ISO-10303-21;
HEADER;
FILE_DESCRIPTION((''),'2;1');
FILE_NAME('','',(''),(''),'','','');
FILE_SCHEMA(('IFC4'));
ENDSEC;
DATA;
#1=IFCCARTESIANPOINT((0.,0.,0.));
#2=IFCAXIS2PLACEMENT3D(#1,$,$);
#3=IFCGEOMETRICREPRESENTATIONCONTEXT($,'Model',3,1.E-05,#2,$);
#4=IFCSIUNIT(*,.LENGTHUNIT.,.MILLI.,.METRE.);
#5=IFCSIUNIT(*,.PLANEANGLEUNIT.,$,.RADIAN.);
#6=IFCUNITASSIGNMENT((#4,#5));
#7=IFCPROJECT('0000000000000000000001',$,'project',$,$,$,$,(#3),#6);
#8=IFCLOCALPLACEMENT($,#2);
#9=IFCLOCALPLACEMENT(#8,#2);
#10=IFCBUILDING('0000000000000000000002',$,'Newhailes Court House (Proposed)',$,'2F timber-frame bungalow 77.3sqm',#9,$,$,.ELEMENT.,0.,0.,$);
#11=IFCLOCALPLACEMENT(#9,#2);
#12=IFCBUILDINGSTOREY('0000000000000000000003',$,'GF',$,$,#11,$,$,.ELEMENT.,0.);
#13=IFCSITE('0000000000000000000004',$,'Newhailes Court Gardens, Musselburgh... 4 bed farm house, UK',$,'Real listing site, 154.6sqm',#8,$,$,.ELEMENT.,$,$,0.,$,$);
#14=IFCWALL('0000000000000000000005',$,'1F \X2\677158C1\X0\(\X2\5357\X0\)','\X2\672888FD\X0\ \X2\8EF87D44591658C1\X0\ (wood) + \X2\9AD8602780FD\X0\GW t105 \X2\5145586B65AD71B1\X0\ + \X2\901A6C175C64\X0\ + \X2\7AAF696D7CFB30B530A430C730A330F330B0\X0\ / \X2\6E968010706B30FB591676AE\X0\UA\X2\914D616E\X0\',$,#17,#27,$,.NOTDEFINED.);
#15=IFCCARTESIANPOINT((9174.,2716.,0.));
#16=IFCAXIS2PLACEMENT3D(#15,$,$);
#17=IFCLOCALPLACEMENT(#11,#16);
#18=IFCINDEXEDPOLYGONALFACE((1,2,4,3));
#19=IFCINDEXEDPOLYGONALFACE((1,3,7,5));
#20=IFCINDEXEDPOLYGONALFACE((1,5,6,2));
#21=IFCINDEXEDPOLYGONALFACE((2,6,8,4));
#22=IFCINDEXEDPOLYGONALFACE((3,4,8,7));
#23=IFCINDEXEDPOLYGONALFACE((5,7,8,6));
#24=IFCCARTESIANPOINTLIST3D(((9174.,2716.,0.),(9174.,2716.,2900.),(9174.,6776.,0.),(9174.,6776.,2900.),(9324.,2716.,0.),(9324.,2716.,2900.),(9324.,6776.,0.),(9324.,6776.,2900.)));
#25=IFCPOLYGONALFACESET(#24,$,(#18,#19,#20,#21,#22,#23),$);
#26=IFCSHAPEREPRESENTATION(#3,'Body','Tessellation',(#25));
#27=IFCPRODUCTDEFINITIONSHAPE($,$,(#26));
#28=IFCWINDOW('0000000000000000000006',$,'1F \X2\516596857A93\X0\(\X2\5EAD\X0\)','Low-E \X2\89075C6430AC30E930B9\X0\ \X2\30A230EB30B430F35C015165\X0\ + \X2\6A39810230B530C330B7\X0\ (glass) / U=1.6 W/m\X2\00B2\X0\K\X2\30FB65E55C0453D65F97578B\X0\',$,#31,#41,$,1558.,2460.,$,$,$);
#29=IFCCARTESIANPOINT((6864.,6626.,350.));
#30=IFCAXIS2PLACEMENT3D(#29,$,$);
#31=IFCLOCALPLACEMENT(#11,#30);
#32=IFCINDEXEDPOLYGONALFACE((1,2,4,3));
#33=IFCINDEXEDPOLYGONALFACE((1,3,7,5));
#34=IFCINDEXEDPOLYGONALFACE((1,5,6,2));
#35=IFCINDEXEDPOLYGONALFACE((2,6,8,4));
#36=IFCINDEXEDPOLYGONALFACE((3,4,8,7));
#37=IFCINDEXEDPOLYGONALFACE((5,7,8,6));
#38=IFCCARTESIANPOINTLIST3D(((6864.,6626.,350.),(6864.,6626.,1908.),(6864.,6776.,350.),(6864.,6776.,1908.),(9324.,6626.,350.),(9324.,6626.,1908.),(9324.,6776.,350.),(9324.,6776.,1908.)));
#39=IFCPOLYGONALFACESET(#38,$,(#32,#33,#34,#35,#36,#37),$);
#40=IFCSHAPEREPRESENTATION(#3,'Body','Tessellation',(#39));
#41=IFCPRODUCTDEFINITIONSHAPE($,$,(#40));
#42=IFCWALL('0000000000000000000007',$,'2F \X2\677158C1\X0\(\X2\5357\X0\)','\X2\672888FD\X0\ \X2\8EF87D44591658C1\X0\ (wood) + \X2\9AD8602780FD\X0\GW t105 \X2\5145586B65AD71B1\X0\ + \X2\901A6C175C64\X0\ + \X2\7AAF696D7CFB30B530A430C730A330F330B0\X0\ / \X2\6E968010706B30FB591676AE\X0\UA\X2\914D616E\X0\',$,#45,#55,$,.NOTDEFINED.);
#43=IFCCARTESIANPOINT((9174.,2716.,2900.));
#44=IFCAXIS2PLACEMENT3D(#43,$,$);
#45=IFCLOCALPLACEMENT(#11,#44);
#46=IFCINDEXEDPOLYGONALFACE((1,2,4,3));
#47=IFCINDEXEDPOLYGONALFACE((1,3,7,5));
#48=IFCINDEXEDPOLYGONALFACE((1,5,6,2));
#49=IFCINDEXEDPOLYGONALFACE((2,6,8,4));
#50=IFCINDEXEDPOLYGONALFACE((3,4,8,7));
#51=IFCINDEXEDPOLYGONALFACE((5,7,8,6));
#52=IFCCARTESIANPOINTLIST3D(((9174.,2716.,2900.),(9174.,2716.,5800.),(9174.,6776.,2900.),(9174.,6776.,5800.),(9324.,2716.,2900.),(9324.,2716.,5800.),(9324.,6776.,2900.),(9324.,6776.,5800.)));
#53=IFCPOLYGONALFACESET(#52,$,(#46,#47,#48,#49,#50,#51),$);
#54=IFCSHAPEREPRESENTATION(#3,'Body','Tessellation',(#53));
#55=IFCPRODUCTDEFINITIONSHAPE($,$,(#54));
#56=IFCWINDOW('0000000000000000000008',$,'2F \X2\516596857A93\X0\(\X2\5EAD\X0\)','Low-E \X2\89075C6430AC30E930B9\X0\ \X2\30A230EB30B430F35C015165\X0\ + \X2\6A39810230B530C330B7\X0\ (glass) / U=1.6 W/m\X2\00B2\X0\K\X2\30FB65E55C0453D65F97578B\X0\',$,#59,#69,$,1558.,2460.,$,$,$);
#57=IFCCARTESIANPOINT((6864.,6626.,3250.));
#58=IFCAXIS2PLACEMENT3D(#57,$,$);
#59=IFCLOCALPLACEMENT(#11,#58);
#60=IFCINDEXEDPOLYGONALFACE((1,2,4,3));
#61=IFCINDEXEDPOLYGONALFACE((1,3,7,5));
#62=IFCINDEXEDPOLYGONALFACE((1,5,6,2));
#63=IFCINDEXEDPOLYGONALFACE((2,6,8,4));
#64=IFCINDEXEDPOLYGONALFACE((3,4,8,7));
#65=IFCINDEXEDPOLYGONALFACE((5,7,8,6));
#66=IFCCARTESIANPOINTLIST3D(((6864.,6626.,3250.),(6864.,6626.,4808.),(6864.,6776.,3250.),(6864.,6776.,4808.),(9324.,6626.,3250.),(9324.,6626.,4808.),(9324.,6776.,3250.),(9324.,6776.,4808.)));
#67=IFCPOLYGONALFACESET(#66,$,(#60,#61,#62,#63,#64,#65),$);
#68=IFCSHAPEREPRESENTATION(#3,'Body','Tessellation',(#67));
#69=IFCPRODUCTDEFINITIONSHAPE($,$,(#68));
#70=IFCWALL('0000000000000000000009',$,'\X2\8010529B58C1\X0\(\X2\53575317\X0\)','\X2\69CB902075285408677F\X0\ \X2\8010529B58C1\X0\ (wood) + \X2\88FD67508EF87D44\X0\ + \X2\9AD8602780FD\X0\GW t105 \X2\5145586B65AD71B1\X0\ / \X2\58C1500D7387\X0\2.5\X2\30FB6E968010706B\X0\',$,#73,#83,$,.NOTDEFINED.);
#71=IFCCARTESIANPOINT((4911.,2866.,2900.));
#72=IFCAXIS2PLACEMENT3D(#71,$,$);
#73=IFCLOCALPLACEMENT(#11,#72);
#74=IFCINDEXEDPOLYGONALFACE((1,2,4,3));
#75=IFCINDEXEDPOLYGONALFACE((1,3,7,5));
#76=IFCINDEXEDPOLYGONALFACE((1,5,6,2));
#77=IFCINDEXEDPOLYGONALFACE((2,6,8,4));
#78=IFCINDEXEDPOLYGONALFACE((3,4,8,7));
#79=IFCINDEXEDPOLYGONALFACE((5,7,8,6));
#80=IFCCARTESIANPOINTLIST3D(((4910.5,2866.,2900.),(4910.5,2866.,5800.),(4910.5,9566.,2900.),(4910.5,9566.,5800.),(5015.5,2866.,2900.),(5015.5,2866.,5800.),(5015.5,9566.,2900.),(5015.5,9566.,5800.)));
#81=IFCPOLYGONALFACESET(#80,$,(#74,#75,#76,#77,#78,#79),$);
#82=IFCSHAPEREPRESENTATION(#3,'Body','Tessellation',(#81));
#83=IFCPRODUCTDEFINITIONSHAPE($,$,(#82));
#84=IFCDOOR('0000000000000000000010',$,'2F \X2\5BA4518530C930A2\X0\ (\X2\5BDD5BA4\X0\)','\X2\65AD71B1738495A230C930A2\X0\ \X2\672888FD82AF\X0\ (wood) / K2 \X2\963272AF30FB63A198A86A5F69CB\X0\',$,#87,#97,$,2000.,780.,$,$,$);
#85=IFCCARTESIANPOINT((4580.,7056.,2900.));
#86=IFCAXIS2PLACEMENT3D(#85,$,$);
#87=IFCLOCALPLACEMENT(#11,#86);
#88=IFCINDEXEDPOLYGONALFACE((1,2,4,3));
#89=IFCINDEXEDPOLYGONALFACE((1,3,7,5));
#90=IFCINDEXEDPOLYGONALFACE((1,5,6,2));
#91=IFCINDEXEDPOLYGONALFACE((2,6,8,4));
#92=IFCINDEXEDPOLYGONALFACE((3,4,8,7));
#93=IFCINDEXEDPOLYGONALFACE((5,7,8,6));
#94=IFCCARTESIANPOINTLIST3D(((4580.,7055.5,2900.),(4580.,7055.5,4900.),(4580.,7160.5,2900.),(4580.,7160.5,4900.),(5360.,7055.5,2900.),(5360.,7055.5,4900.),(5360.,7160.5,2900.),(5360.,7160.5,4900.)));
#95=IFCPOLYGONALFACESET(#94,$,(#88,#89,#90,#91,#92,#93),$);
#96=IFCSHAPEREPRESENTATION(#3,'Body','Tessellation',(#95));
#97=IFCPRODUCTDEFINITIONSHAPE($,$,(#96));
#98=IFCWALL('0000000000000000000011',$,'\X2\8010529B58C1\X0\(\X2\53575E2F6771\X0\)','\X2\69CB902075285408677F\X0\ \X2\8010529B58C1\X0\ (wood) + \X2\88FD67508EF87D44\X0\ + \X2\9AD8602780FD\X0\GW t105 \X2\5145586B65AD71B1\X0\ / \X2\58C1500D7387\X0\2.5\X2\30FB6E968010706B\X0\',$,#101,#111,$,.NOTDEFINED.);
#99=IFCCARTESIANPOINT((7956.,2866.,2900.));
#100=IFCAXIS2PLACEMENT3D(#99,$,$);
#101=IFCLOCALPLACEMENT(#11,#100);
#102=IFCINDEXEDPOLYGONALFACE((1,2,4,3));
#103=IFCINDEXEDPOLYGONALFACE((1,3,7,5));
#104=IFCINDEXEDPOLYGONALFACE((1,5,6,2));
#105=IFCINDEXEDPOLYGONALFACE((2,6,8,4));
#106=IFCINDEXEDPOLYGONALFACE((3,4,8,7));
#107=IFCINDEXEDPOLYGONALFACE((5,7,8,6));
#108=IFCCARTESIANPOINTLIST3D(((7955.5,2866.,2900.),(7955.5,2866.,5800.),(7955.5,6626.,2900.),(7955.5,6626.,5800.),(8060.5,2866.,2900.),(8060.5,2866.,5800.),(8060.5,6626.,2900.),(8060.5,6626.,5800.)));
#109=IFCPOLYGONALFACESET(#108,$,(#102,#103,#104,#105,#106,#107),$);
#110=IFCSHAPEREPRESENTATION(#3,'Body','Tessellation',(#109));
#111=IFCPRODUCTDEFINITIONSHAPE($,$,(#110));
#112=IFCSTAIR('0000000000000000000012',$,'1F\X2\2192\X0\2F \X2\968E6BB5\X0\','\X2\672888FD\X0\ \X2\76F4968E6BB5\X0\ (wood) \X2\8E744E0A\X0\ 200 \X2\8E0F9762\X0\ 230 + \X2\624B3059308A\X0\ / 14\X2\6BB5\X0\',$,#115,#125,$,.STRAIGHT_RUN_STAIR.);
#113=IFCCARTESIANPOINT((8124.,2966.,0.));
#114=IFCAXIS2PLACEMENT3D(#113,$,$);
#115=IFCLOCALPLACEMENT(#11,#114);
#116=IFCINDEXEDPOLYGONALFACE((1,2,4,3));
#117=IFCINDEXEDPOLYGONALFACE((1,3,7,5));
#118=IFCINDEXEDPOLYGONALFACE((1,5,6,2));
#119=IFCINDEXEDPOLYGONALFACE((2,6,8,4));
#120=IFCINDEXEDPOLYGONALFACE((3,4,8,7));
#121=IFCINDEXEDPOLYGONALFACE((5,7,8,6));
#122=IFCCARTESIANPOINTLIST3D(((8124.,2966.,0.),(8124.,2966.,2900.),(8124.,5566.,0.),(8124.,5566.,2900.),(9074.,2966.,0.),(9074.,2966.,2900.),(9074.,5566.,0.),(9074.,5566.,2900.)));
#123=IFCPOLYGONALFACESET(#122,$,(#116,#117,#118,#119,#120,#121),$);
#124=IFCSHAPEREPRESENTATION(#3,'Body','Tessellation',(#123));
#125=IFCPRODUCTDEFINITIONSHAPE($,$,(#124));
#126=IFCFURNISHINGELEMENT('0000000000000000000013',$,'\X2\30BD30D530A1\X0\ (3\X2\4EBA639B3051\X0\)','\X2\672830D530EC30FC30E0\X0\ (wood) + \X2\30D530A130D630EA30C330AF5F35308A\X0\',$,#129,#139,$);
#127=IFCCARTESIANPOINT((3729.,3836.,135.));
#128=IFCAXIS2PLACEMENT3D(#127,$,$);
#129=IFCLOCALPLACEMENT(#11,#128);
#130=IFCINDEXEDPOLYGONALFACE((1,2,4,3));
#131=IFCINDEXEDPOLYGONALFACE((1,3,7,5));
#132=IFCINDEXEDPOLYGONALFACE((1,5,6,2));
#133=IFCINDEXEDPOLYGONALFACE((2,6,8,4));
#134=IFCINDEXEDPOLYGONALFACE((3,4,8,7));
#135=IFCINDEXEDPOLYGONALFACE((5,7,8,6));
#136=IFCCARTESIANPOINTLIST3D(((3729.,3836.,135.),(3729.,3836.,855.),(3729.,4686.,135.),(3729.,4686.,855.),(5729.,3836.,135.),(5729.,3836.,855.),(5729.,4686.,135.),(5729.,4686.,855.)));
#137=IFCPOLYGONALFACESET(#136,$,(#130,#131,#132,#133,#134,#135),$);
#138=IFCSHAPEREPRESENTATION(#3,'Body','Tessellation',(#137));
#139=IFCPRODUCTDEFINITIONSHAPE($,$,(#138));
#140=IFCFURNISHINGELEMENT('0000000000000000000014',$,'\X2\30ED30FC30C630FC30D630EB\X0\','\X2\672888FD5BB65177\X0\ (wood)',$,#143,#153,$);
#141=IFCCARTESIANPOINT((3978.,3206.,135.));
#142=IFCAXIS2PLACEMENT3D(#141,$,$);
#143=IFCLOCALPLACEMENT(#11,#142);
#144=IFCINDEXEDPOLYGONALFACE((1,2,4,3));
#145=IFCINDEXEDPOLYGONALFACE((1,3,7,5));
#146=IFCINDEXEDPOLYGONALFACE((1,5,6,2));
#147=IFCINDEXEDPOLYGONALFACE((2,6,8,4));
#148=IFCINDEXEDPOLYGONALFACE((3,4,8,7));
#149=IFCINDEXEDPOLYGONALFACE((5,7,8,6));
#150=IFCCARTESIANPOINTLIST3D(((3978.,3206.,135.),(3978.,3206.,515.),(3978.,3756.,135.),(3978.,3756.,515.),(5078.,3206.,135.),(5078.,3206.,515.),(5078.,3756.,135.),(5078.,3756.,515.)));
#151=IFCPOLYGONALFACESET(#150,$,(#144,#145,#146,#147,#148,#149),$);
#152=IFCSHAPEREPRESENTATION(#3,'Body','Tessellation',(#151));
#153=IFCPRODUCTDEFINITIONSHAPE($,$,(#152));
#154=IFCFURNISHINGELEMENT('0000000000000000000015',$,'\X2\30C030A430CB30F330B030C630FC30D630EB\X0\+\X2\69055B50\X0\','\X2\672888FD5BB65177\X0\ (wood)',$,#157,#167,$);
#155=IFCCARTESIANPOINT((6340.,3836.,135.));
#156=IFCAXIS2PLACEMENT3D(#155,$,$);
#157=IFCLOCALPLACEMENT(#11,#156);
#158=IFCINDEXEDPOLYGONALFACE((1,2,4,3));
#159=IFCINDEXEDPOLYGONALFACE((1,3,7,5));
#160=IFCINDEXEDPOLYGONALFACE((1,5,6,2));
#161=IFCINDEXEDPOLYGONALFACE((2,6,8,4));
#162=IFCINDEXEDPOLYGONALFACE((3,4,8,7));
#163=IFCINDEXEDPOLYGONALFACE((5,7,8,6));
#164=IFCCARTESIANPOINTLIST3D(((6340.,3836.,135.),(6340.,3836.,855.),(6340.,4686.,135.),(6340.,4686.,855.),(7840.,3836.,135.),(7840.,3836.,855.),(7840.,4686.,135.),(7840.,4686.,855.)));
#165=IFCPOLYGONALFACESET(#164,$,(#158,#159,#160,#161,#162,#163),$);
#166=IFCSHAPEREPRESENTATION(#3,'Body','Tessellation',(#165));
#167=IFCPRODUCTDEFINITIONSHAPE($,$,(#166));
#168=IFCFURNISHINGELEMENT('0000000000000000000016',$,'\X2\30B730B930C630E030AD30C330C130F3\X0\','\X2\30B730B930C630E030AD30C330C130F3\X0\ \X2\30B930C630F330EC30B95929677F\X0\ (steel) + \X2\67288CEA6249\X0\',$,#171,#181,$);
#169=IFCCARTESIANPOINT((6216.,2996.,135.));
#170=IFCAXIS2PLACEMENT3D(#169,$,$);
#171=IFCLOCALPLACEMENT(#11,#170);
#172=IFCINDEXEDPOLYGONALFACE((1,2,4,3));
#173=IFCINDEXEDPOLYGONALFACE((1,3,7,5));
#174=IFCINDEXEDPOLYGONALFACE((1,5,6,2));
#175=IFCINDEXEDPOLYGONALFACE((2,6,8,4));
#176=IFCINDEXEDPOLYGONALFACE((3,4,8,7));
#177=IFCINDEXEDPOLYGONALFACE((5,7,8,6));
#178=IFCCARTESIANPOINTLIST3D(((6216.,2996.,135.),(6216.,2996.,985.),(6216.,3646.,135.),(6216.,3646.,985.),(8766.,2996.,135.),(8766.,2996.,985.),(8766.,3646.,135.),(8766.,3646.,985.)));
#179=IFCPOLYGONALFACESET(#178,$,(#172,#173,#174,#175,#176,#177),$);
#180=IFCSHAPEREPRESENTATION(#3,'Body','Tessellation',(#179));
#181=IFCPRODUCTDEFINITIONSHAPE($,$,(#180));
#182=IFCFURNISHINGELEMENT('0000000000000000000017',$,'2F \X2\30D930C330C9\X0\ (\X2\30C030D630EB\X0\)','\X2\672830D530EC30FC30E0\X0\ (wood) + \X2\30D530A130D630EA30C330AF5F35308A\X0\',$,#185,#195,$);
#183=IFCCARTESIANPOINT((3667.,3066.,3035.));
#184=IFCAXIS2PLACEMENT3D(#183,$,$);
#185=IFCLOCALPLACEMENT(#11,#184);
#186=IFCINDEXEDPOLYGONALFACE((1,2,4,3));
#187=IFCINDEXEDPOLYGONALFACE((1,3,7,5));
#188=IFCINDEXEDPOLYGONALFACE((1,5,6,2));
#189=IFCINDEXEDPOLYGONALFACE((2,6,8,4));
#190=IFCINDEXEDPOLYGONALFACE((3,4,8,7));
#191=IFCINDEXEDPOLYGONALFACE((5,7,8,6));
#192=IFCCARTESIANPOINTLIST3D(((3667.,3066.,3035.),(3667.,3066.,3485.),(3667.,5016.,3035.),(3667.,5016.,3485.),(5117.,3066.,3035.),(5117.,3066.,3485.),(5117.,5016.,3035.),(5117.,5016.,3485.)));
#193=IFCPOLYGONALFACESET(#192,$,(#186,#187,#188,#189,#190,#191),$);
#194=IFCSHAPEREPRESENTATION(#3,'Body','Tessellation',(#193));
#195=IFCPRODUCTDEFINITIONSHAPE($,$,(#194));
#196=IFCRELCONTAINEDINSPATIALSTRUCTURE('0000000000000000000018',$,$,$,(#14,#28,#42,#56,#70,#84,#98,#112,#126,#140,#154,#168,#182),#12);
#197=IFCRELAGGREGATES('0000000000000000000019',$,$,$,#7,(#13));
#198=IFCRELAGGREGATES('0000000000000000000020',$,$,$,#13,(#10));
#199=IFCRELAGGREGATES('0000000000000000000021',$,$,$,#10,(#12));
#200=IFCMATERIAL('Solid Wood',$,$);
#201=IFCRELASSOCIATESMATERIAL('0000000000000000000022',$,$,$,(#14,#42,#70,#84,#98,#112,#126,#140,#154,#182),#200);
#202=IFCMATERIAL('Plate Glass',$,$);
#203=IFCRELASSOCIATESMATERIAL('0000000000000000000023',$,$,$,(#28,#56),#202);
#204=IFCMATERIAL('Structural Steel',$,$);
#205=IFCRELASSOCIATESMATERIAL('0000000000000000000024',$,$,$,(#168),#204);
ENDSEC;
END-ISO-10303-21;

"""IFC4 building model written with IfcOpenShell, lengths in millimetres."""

from ifc_helpers import new_model, si_unit, frame, frame_2d, origin, place, context, project, spatial, rectangle, extrude, material, element, fill, save


model = new_model("IFC4")

# Units and contexts
model_context = context("Model", 3, precision=1e-05, world=origin())
ifc_project = project(units=[si_unit("LENGTHUNIT", "METRE", prefix="MILLI"), si_unit("PLANEANGLEUNIT", "RADIAN")], contexts=[model_context])

# Site, building, storey
site_placement = place(None, origin())
site = spatial("IfcSite", under=ifc_project, at=site_placement, Name="Newhailes Court Gardens, Musselburgh... 4 bed farm house, UK", ObjectType="Real listing site, 154.6sqm", CompositionType="ELEMENT", RefElevation=0.0)
building_placement = place(site_placement, origin())
building = spatial("IfcBuilding", under=site, at=building_placement, Name="Newhailes Court House (Proposed)", ObjectType="2F timber-frame bungalow 77.3sqm", CompositionType="ELEMENT", ElevationOfRefHeight=0.0, ElevationOfTerrain=0.0)
storey_placement = place(building_placement, origin())
storey = spatial("IfcBuildingStorey", under=building, at=storey_placement, Name="GF", CompositionType="ELEMENT", Elevation=0.0)

# Wall, opening, window
ifc_material_1 = material(Name="Solid Wood")
wall_1_placement = place(storey_placement, frame((9174.0, 2716.0, 0.0)))
wall_1 = element("IfcWall", 1, at=wall_1_placement, inside=storey, material=ifc_material_1, Name="1F 東壁(南)", Description="木製 軸組外壁 (wood) + 高性能GW t105 充填断熱 + 通気層 + 窯業系サイディング / 準耐火・外皮UA配慮", PredefinedType="NOTDEFINED", context=model_context, shape_type="SweptSolid", body=[
    extrude(rectangle(XDim=150.0, YDim=4060.0, at=frame_2d((75.0, 2030.0))), frame((9174.0, 2716.0, 0.0)), (0.0, 0.0, 1.0), 2900.0),
])
opening_1_placement = place(storey_placement, frame((6864.0, 6626.0, 350.0)))
opening_1 = element("IfcOpeningElement", 2, at=opening_1_placement, cuts=wall_1, PredefinedType="NOTDEFINED", context=model_context, shape_type="SweptSolid", body=[
    extrude(rectangle(XDim=2460.0, YDim=150.0, at=frame_2d((1230.0, 75.0))), frame((6864.0, 6626.0, 350.0)), (0.0, 0.0, 1.0), 1558.0),
])
ifc_material_2 = material(Name="Plate Glass")
window_1_placement = place(storey_placement, frame((6864.0, 6626.0, 350.0)))
window_1 = element("IfcWindow", 3, at=window_1_placement, inside=storey, material=ifc_material_2, Name="1F 入隅窓(庭)", Description="Low-E 複層ガラス アルゴン封入 + 樹脂サッシ (glass) / U=1.6 W/m²K・日射取得型", OverallHeight=1558.0, OverallWidth=2460.0, context=model_context, shape_type="SweptSolid", body=[
    extrude(rectangle(XDim=2460.0, YDim=150.0, at=frame_2d((1230.0, 75.0))), frame((6864.0, 6626.0, 350.0)), (0.0, 0.0, 1.0), 1558.0),
])
fill(opening_1, window_1)

# Wall, opening, window
wall_2_placement = place(storey_placement, frame((9174.0, 2716.0, 2900.0)))
wall_2 = element("IfcWall", 4, at=wall_2_placement, inside=storey, material=ifc_material_1, Name="2F 東壁(南)", Description="木製 軸組外壁 (wood) + 高性能GW t105 充填断熱 + 通気層 + 窯業系サイディング / 準耐火・外皮UA配慮", PredefinedType="NOTDEFINED", context=model_context, shape_type="SweptSolid", body=[
    extrude(rectangle(XDim=150.0, YDim=4060.0, at=frame_2d((75.0, 2030.0))), frame((9174.0, 2716.0, 2900.0)), (0.0, 0.0, 1.0), 2900.0),
])
opening_2_placement = place(storey_placement, frame((6864.0, 6626.0, 3250.0)))
opening_2 = element("IfcOpeningElement", 5, at=opening_2_placement, cuts=wall_2, PredefinedType="NOTDEFINED", context=model_context, shape_type="SweptSolid", body=[
    extrude(rectangle(XDim=2460.0, YDim=150.0, at=frame_2d((1230.0, 75.0))), frame((6864.0, 6626.0, 3250.0)), (0.0, 0.0, 1.0), 1558.0),
])
window_2_placement = place(storey_placement, frame((6864.0, 6626.0, 3250.0)))
window_2 = element("IfcWindow", 6, at=window_2_placement, inside=storey, material=ifc_material_2, Name="2F 入隅窓(庭)", Description="Low-E 複層ガラス アルゴン封入 + 樹脂サッシ (glass) / U=1.6 W/m²K・日射取得型", OverallHeight=1558.0, OverallWidth=2460.0, context=model_context, shape_type="SweptSolid", body=[
    extrude(rectangle(XDim=2460.0, YDim=150.0, at=frame_2d((1230.0, 75.0))), frame((6864.0, 6626.0, 3250.0)), (0.0, 0.0, 1.0), 1558.0),
])
fill(opening_2, window_2)

# Wall, opening, door
wall_3_placement = place(storey_placement, frame((4911.0, 2866.0, 2900.0)))
wall_3 = element("IfcWall", 7, at=wall_3_placement, inside=storey, material=ifc_material_1, Name="耐力壁(南北)", Description="構造用合板 耐力壁 (wood) + 製材軸組 + 高性能GW t105 充填断熱 / 壁倍率2.5・準耐火", PredefinedType="NOTDEFINED", context=model_context, shape_type="SweptSolid", body=[
    extrude(rectangle(XDim=105.0, YDim=6700.0, at=frame_2d((52.0, 3350.0))), frame((4911.0, 2866.0, 2900.0)), (0.0, 0.0, 1.0), 2900.0),
])
opening_3_placement = place(storey_placement, frame((4580.0, 7056.0, 2900.0)))
opening_3 = element("IfcOpeningElement", 8, at=opening_3_placement, cuts=wall_3, PredefinedType="NOTDEFINED", context=model_context, shape_type="SweptSolid", body=[
    extrude(rectangle(XDim=780.0, YDim=105.0, at=frame_2d((390.0, 52.0))), frame((4580.0, 7056.0, 2900.0)), (0.0, 0.0, 1.0), 2000.0),
])
door_1_placement = place(storey_placement, frame((4580.0, 7056.0, 2900.0)))
door_1 = element("IfcDoor", 9, at=door_1_placement, inside=storey, material=ifc_material_1, Name="2F 室内ドア (寝室)", Description="断熱玄関ドア 木製芯 (wood) / K2 防犯・採風機構", OverallHeight=2000.0, OverallWidth=780.0, context=model_context, shape_type="SweptSolid", body=[
    extrude(rectangle(XDim=780.0, YDim=105.0, at=frame_2d((390.0, 52.0))), frame((4580.0, 7056.0, 2900.0)), (0.0, 0.0, 1.0), 2000.0),
])
fill(opening_3, door_1)

# Wall
wall_4_placement = place(storey_placement, frame((7956.0, 2866.0, 2900.0)))
element("IfcWall", 10, at=wall_4_placement, inside=storey, material=ifc_material_1, Name="耐力壁(南帯東)", Description="構造用合板 耐力壁 (wood) + 製材軸組 + 高性能GW t105 充填断熱 / 壁倍率2.5・準耐火", PredefinedType="NOTDEFINED", context=model_context, shape_type="SweptSolid", body=[
    extrude(rectangle(XDim=105.0, YDim=3760.0, at=frame_2d((52.0, 1880.0))), frame((7956.0, 2866.0, 2900.0)), (0.0, 0.0, 1.0), 2900.0),
])

# Stair
stair_placement = place(storey_placement, frame((8124.0, 2966.0, 0.0)))
element("IfcStair", 11, at=stair_placement, inside=storey, material=ifc_material_1, Name="1F→2F 階段", Description="木製 直階段 (wood) 蹴上 200 踏面 230 + 手すり / 14段", PredefinedType="STRAIGHT_RUN_STAIR", context=model_context, shape_type="SweptSolid", body=[
    extrude(rectangle(XDim=950.0, YDim=2600.0, at=frame_2d((475.0, 1300.0))), frame((8124.0, 2966.0, 0.0)), (0.0, 0.0, 1.0), 2900.0),
])

# Furnishing elements
furnishing_1_placement = place(storey_placement, frame((3729.0, 3836.0, 135.0)))
element("IfcFurnishingElement", 12, at=furnishing_1_placement, inside=storey, material=ifc_material_1, Name="ソファ (3人掛け)", Description="木フレーム (wood) + ファブリック張り", context=model_context, shape_type="SweptSolid", body=[
    extrude(rectangle(XDim=2000.0, YDim=850.0, at=frame_2d((1000.0, 425.0))), frame((3729.0, 3836.0, 135.0)), (0.0, 0.0, 1.0), 720.0),
])
furnishing_2_placement = place(storey_placement, frame((3978.0, 3206.0, 135.0)))
element("IfcFurnishingElement", 13, at=furnishing_2_placement, inside=storey, material=ifc_material_1, Name="ローテーブル", Description="木製家具 (wood)", context=model_context, shape_type="SweptSolid", body=[
    extrude(rectangle(XDim=1100.0, YDim=550.0, at=frame_2d((550.0, 275.0))), frame((3978.0, 3206.0, 135.0)), (0.0, 0.0, 1.0), 380.0),
])
furnishing_3_placement = place(storey_placement, frame((6340.0, 3836.0, 135.0)))
element("IfcFurnishingElement", 14, at=furnishing_3_placement, inside=storey, material=ifc_material_1, Name="ダイニングテーブル+椅子", Description="木製家具 (wood)", context=model_context, shape_type="SweptSolid", body=[
    extrude(rectangle(XDim=1500.0, YDim=850.0, at=frame_2d((750.0, 425.0))), frame((6340.0, 3836.0, 135.0)), (0.0, 0.0, 1.0), 720.0),
])
ifc_material_3 = material(Name="Structural Steel")
furnishing_4_placement = place(storey_placement, frame((6216.0, 2996.0, 135.0)))
element("IfcFurnishingElement", 15, at=furnishing_4_placement, inside=storey, material=ifc_material_3, Name="システムキッチン", Description="システムキッチン ステンレス天板 (steel) + 木質扉", context=model_context, shape_type="SweptSolid", body=[
    extrude(rectangle(XDim=2550.0, YDim=650.0, at=frame_2d((1275.0, 325.0))), frame((6216.0, 2996.0, 135.0)), (0.0, 0.0, 1.0), 850.0),
])
furnishing_5_placement = place(storey_placement, frame((3667.0, 3066.0, 3035.0)))
element("IfcFurnishingElement", 16, at=furnishing_5_placement, inside=storey, material=ifc_material_1, Name="2F ベッド (ダブル)", Description="木フレーム (wood) + ファブリック張り", context=model_context, shape_type="SweptSolid", body=[
    extrude(rectangle(XDim=1450.0, YDim=1950.0, at=frame_2d((725.0, 975.0))), frame((3667.0, 3066.0, 3035.0)), (0.0, 0.0, 1.0), 450.0),
])

save(model, "model.ifc")
